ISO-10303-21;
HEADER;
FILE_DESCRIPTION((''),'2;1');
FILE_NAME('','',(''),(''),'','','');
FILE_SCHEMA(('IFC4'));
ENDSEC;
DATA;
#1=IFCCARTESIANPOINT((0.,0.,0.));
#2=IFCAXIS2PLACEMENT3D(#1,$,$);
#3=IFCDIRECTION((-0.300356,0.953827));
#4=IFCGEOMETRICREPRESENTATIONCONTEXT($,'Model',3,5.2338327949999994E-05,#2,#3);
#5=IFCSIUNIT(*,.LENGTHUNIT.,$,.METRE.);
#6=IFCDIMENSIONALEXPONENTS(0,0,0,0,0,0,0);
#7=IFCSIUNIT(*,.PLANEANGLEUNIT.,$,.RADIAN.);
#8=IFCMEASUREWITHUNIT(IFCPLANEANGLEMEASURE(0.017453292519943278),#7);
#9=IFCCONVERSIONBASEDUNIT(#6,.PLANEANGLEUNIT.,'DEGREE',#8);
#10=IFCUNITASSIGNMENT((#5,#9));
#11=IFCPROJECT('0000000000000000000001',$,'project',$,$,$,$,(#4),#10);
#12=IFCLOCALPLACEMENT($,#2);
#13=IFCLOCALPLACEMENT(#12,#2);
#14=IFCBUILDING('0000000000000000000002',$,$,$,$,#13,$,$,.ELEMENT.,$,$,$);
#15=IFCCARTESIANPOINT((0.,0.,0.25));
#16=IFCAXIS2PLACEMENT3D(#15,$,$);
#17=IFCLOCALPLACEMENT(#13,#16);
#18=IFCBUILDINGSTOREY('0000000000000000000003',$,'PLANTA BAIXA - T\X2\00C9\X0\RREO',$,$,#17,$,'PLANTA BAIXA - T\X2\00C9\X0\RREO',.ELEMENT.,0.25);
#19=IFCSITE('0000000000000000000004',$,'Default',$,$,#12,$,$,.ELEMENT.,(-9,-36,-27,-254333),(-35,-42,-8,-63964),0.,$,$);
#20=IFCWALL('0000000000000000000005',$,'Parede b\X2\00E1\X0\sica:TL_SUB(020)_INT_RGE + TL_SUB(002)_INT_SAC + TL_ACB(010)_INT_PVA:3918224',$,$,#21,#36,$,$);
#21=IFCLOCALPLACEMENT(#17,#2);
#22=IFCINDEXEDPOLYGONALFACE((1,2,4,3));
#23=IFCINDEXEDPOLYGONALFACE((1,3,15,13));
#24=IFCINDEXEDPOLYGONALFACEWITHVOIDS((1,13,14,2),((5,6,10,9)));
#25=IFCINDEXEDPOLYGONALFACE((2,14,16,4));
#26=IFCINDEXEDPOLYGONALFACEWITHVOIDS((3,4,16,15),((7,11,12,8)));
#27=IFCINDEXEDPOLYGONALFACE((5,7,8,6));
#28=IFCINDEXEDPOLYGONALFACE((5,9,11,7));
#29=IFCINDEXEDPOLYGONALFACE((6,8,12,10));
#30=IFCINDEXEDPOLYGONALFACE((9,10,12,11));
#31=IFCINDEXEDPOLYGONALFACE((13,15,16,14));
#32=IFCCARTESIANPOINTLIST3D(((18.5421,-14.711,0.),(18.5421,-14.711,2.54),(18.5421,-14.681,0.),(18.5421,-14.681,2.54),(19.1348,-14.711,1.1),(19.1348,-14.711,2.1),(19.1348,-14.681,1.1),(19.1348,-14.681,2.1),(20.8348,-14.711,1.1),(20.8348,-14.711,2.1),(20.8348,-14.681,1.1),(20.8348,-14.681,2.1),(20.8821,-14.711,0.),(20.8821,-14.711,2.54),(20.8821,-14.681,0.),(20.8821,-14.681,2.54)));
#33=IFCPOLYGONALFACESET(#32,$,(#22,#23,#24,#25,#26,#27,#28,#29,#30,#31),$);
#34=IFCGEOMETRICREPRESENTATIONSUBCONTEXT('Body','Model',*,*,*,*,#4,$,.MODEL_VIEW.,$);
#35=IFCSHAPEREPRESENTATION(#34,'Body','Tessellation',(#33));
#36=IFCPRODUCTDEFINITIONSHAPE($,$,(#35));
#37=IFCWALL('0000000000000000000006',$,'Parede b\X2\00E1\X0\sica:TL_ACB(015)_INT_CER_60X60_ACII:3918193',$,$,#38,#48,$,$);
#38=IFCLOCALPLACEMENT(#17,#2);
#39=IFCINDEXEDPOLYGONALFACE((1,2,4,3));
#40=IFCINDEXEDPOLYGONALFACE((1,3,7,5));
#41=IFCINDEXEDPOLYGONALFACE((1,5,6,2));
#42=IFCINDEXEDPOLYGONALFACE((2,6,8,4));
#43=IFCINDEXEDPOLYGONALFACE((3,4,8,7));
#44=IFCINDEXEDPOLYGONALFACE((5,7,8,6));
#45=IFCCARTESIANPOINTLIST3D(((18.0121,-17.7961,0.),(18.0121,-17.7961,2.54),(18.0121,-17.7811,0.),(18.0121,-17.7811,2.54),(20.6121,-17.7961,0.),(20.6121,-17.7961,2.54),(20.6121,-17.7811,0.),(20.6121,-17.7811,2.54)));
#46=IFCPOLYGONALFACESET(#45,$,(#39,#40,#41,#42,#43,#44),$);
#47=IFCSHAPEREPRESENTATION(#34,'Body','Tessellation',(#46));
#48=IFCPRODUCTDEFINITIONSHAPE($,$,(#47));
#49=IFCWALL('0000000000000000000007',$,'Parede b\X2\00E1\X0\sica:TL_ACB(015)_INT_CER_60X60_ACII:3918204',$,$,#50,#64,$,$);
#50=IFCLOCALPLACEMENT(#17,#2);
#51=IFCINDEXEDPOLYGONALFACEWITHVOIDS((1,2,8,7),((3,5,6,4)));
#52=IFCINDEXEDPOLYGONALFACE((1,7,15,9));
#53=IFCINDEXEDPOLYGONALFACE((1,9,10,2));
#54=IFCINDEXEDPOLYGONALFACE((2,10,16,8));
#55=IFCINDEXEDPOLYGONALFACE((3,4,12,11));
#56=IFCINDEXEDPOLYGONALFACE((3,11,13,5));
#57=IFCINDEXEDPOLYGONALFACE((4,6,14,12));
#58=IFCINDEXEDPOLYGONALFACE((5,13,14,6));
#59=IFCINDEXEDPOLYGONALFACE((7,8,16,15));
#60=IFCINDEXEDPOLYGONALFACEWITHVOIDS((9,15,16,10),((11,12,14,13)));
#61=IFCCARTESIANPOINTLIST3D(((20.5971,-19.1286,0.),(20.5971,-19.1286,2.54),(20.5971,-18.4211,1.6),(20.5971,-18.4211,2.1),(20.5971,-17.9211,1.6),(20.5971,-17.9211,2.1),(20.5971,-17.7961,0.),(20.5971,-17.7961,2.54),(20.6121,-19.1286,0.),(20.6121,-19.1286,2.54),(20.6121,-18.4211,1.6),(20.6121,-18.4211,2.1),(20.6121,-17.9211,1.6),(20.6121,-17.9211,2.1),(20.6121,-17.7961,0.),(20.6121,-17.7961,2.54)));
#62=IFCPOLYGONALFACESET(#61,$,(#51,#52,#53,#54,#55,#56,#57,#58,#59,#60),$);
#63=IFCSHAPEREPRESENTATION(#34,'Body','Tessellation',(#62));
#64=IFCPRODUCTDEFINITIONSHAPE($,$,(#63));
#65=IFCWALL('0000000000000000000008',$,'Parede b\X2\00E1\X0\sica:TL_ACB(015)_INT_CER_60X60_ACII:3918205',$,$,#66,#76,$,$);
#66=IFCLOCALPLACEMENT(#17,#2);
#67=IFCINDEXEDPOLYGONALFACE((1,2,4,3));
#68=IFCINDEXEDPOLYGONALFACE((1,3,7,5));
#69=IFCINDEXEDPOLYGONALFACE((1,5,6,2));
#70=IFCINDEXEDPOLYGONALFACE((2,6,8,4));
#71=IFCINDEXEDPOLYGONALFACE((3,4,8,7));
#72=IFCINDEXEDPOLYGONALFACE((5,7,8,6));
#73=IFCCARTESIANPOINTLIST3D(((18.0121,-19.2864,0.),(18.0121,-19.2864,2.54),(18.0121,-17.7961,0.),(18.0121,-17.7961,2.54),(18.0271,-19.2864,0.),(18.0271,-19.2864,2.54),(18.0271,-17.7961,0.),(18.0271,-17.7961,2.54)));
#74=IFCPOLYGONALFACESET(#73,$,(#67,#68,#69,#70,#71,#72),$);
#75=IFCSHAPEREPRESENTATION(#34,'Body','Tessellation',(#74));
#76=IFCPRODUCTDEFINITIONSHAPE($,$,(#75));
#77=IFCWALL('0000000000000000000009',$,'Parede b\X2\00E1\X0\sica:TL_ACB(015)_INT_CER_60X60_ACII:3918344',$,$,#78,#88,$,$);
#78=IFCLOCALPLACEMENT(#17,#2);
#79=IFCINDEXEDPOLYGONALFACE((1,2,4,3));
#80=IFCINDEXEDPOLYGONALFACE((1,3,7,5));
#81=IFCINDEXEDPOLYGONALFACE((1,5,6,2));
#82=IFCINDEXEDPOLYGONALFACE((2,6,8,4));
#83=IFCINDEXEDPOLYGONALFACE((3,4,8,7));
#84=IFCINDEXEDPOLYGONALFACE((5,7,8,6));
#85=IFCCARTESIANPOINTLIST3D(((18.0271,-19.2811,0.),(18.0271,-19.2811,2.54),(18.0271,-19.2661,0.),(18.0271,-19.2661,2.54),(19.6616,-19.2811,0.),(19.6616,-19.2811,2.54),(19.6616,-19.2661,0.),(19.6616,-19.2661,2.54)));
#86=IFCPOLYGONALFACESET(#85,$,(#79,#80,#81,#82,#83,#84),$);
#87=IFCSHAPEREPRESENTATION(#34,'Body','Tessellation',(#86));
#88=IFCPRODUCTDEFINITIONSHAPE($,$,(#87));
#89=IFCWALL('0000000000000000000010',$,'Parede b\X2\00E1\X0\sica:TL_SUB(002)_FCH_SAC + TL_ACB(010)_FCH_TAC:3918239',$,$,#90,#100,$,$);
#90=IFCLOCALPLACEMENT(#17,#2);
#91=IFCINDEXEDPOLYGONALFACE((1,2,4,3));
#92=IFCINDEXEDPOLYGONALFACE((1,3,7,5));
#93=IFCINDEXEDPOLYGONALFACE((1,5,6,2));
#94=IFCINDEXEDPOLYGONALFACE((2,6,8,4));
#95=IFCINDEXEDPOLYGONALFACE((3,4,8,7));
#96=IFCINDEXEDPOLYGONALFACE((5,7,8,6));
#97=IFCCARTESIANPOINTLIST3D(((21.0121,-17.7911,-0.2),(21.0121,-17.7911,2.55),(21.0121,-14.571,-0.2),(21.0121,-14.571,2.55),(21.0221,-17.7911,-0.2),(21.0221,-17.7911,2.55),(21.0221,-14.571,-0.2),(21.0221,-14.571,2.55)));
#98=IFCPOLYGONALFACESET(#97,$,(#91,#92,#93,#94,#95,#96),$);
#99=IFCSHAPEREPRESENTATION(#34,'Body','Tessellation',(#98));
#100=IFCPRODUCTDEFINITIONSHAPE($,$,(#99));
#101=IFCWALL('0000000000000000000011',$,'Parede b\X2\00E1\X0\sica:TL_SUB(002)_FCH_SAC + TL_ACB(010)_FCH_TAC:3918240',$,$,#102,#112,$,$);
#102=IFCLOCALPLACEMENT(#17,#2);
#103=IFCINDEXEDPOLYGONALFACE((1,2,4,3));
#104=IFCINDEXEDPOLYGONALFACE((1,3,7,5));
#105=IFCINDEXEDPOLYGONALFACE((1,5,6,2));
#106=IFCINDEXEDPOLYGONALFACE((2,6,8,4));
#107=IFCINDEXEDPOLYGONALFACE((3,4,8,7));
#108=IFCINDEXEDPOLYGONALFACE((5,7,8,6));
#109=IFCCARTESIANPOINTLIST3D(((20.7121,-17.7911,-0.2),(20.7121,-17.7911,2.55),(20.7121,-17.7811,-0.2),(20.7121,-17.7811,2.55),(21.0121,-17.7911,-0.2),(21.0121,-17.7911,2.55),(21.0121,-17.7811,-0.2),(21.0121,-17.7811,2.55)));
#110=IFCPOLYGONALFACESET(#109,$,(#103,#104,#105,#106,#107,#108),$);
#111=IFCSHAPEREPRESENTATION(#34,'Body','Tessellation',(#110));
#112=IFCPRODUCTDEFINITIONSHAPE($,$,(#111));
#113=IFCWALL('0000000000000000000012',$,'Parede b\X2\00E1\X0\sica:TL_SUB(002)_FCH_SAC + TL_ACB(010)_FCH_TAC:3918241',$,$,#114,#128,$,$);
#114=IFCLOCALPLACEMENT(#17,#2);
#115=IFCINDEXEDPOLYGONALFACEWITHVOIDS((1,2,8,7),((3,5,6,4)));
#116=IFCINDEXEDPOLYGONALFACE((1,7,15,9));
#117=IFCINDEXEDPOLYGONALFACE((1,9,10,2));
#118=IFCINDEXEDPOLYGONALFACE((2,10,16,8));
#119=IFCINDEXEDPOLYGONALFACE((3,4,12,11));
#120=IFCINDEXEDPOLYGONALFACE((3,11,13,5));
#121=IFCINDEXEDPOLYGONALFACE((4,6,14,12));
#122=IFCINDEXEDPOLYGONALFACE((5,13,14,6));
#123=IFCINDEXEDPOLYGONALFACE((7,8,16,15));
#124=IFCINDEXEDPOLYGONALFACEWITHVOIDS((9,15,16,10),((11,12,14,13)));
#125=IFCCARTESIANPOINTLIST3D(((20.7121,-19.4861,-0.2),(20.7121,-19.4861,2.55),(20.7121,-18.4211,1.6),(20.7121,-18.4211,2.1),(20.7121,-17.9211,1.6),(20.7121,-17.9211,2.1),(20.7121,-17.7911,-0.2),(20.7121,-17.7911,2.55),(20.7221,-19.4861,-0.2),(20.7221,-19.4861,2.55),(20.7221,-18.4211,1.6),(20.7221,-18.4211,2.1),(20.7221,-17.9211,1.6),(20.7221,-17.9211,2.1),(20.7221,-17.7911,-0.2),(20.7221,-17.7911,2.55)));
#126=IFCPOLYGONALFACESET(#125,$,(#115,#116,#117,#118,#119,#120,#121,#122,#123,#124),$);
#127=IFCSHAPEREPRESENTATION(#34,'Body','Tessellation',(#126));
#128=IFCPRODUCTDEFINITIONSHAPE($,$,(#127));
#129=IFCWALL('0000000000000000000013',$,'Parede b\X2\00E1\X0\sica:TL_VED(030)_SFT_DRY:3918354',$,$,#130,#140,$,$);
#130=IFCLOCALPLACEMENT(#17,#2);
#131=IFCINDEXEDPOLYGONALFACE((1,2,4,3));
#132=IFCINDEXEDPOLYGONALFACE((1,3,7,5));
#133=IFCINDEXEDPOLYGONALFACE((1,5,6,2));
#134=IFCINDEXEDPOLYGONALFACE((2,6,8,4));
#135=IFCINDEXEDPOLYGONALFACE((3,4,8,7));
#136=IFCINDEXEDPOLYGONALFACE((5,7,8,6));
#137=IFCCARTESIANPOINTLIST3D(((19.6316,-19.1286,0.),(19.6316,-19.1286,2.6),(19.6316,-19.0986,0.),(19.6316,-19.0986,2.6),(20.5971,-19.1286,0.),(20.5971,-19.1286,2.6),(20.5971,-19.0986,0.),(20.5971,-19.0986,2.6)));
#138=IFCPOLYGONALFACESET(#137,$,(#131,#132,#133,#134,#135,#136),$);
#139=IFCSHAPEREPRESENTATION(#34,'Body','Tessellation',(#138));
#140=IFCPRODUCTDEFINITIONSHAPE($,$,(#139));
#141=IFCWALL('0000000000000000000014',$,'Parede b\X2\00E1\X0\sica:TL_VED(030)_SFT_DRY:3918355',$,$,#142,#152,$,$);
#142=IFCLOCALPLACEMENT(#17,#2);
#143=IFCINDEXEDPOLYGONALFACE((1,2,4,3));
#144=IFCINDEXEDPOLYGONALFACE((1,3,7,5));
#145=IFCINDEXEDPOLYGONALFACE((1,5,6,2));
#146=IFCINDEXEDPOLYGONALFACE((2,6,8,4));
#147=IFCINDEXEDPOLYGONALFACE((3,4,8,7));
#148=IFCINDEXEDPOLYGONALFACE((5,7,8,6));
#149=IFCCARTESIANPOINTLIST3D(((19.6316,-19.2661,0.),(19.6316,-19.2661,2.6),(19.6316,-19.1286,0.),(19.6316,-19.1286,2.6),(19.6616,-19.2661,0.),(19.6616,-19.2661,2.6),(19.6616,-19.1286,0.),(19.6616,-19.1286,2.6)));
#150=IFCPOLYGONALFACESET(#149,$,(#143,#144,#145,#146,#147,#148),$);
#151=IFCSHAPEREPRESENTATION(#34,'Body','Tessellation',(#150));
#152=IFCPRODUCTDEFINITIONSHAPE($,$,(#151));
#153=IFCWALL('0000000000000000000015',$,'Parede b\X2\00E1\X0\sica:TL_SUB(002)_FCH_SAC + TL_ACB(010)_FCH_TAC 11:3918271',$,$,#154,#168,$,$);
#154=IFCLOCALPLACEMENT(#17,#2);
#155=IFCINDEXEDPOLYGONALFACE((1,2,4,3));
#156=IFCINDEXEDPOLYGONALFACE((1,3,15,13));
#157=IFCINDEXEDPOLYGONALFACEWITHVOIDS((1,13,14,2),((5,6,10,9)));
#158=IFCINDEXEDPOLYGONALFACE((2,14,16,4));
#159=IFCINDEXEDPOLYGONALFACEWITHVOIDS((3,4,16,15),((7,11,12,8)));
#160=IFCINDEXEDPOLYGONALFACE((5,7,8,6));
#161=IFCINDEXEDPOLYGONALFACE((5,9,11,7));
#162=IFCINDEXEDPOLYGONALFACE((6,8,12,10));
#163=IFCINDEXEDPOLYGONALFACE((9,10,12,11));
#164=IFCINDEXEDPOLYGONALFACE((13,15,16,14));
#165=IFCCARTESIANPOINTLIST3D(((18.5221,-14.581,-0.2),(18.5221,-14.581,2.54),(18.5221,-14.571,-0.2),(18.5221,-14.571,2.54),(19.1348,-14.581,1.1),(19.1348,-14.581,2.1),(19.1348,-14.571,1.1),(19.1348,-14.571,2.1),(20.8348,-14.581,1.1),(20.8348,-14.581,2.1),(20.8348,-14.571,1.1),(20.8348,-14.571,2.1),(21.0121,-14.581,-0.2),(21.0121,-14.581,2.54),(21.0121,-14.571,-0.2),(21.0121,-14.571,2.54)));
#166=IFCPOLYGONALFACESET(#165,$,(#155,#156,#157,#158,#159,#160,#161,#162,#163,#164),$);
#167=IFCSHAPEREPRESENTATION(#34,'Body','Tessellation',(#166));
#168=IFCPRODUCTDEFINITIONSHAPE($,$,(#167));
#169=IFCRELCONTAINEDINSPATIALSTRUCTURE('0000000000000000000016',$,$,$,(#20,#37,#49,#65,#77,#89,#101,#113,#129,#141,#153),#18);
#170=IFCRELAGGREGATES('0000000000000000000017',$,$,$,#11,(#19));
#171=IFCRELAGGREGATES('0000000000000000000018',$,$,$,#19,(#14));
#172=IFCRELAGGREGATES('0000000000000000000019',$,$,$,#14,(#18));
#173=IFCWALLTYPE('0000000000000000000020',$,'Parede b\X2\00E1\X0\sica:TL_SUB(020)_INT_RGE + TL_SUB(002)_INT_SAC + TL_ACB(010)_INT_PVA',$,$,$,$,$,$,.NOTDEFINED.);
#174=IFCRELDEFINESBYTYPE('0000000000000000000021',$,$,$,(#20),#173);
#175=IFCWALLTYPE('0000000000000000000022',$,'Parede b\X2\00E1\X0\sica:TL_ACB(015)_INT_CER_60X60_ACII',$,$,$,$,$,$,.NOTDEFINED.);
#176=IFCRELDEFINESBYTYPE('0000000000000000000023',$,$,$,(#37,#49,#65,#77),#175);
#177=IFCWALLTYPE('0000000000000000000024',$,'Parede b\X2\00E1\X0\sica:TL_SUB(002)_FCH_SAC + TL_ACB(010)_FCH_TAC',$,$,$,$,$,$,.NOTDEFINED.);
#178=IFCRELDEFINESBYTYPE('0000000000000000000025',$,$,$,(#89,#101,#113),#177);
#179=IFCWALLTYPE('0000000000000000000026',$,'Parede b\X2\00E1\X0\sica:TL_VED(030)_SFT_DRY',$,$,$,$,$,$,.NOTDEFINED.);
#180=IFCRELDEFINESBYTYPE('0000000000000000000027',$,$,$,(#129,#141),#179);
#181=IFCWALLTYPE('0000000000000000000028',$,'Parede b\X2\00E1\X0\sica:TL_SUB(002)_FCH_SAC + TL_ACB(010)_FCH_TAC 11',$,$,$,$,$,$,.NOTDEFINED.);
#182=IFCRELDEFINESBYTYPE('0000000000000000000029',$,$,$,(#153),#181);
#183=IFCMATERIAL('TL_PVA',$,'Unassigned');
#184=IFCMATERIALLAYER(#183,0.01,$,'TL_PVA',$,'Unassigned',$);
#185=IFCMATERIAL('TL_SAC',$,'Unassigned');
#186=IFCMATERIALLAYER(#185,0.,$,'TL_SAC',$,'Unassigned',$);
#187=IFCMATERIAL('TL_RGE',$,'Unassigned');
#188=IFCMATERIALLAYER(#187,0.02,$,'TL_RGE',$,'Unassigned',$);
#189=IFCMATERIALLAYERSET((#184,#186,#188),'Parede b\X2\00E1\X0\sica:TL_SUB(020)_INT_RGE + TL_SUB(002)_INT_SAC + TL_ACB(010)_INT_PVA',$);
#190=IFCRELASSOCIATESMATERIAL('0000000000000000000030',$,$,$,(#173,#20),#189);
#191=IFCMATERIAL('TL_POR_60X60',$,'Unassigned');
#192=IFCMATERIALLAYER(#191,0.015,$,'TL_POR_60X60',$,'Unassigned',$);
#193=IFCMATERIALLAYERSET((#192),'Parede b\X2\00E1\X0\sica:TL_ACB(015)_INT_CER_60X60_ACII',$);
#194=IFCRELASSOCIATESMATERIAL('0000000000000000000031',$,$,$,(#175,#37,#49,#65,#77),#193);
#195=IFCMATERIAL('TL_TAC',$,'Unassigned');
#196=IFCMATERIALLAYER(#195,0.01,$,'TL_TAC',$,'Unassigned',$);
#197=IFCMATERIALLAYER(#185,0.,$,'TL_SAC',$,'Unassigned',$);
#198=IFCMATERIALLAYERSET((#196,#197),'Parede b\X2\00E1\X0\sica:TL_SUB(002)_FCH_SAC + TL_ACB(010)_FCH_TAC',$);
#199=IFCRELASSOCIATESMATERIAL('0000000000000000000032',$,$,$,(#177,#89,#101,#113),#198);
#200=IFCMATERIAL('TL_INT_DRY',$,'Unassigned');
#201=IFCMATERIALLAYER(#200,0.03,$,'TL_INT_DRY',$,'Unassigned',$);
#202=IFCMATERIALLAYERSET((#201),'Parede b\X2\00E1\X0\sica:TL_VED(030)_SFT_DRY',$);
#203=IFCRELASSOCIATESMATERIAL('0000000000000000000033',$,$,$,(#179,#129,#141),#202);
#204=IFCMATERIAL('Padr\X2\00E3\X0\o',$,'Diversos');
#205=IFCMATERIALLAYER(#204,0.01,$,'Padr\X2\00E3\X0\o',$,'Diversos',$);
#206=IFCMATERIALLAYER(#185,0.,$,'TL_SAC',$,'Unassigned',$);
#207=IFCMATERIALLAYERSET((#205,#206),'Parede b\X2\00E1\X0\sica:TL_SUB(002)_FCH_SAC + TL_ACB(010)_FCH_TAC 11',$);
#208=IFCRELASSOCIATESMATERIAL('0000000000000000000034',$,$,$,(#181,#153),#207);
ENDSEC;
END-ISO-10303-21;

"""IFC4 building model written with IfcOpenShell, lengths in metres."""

from ifc_helpers import new_model, entity, si_unit, converted_unit, direction, frame, frame_2d, origin, place, context, subcontext, project, spatial, rectangle, extrude, material, layer, layer_set, layer_usage, type_object, element, save


model = new_model("IFC4")

# Units and contexts
model_context = context("Model", 3, precision=5.2338327949999994e-05, world=origin(), true_north=direction((-0.300356, 0.953827)))
body_context = subcontext(model_context, "Body", "Model", "MODEL_VIEW")
ifc_project = project(units=[si_unit("LENGTHUNIT", "METRE"), converted_unit("PLANEANGLEUNIT", "DEGREE", entity("IfcPlaneAngleMeasure", 0.017453292519943278), si_unit("PLANEANGLEUNIT", "RADIAN"), dimensions=[0, 0, 0, 0, 0, 0, 0])], contexts=[model_context])

# Site, building, storey
site_placement = place(None, origin())
site = spatial("IfcSite", under=ifc_project, at=site_placement, Name="Default", CompositionType="ELEMENT", RefLatitude=(-9, -36, -27, -254333), RefLongitude=(-35, -42, -8, -63964), RefElevation=0.0)
building_placement = place(site_placement, origin())
building = spatial("IfcBuilding", under=site, at=building_placement, CompositionType="ELEMENT")
storey_placement = place(building_placement, frame((0.0, 0.0, 0.25)))
storey = spatial("IfcBuildingStorey", under=building, at=storey_placement, Name="PLANTA BAIXA - TÉRREO", LongName="PLANTA BAIXA - TÉRREO", CompositionType="ELEMENT", Elevation=0.25)

# Shared definitions
ifc_material_1 = material(Name="TL_PVA", Category="Unassigned")
ifc_layer_1 = layer(ifc_material_1, 0.01, Name="TL_PVA", Category="Unassigned")
ifc_material_2 = material(Name="TL_SAC", Category="Unassigned")
ifc_layer_2 = layer(ifc_material_2, 0.0, Name="TL_SAC", Category="Unassigned")
ifc_material_3 = material(Name="TL_RGE", Category="Unassigned")
ifc_layer_3 = layer(ifc_material_3, 0.02, Name="TL_RGE", Category="Unassigned")
ifc_layer_set_1 = layer_set([ifc_layer_1, ifc_layer_2, ifc_layer_3], Name="Parede básica:TL_SUB(020)_INT_RGE + TL_SUB(002)_INT_SAC + TL_ACB(010)_INT_PVA")
wall_type_1 = type_object("IfcWallType", Name="Parede básica:TL_SUB(020)_INT_RGE + TL_SUB(002)_INT_SAC + TL_ACB(010)_INT_PVA", PredefinedType="NOTDEFINED", material=ifc_layer_set_1)

# Wall, opening
ifc_layer_usage_1 = layer_usage(ifc_layer_set_1, "AXIS2", "POSITIVE", -0.015)
wall_1_placement = place(storey_placement, frame((18.5421, -14.696, 0.0)))
wall_1 = element("IfcWall", 1, at=wall_1_placement, inside=storey, type_object=wall_type_1, material=ifc_layer_usage_1, Name="Parede básica:TL_SUB(020)_INT_RGE + TL_SUB(002)_INT_SAC + TL_ACB(010)_INT_PVA:3918224", context=body_context, shape_type="SweptSolid", body=[
    extrude(rectangle(XDim=2.34, YDim=0.03, at=frame_2d((1.17, 0.0), x_axis=(-1.0, 0.0))), origin(), (0.0, 0.0, 1.0), 2.54),
])
opening_1_placement = place(wall_1_placement, frame((-18.5421, 14.696, 1.1)))
element("IfcOpeningElement", 2, at=opening_1_placement, cuts=wall_1, PredefinedType="OPENING", context=body_context, shape_type="SweptSolid", body=[
    extrude(rectangle(XDim=1.0, YDim=1.7, at=frame_2d((0.0, 0.0), x_axis=(0.0, 1.0))), frame((19.9848, -16.205, 0.5), z_axis=(0.0, 1.0, 0.0), x_axis=(1.0, 0.0, 0.0)), (0.0, 0.0, 1.0), 3.048),
])

# Wall
ifc_material_4 = material(Name="TL_POR_60X60", Category="Unassigned")
ifc_layer_4 = layer(ifc_material_4, 0.015, Name="TL_POR_60X60", Category="Unassigned")
ifc_layer_set_2 = layer_set([ifc_layer_4], Name="Parede básica:TL_ACB(015)_INT_CER_60X60_ACII")
ifc_layer_usage_2 = layer_usage(ifc_layer_set_2, "AXIS2", "NEGATIVE", 0.0075)
wall_type_2 = type_object("IfcWallType", Name="Parede básica:TL_ACB(015)_INT_CER_60X60_ACII", PredefinedType="NOTDEFINED", material=ifc_layer_set_2)
wall_2_placement = place(storey_placement, frame((20.6121, -17.7886, 0.0), z_axis=(0.0, 0.0, 1.0), x_axis=(-1.0, 0.0, 0.0)))
element("IfcWall", 3, at=wall_2_placement, inside=storey, type_object=wall_type_2, material=ifc_layer_usage_2, Name="Parede básica:TL_ACB(015)_INT_CER_60X60_ACII:3918193", context=body_context, shape_type="SweptSolid", body=[
    extrude(rectangle(XDim=2.6, YDim=0.015, at=frame_2d((1.3, 0.0), x_axis=(-1.0, 0.0))), origin(), (0.0, 0.0, 1.0), 2.54),
])

# Wall, opening
ifc_layer_usage_3 = layer_usage(ifc_layer_set_2, "AXIS2", "POSITIVE", -0.0075)
wall_3_placement = place(storey_placement, frame((20.6046, -17.7961, 0.0), z_axis=(0.0, 0.0, 1.0), x_axis=(0.0, -1.0, 0.0)))
wall_3 = element("IfcWall", 4, at=wall_3_placement, inside=storey, type_object=wall_type_2, material=ifc_layer_usage_3, Name="Parede básica:TL_ACB(015)_INT_CER_60X60_ACII:3918204", context=body_context, shape_type="SweptSolid", body=[
    extrude(rectangle(XDim=1.3325, YDim=0.015, at=frame_2d((0.6662, 0.0), x_axis=(-1.0, 0.0))), origin(), (0.0, 0.0, 1.0), 2.54),
])
opening_2_placement = place(wall_3_placement, frame((-17.7961, -20.6046, 1.6)))
element("IfcOpeningElement", 5, at=opening_2_placement, cuts=wall_3, PredefinedType="OPENING", context=body_context, shape_type="SweptSolid", body=[
    extrude(rectangle(XDim=0.5, YDim=0.5, at=frame_2d((0.0, 0.0), x_axis=(1.0, 0.0))), frame((18.1711, 19.1881, 0.25), z_axis=(0.0, 1.0, 0.0), x_axis=(0.0, 0.0, 1.0)), (0.0, 0.0, 1.0), 3.048),
])

# Walls
ifc_layer_usage_4 = layer_usage(ifc_layer_set_2, "AXIS2", "POSITIVE", -0.0075)
wall_4_placement = place(storey_placement, frame((18.0196, -19.2864, 0.0), z_axis=(0.0, 0.0, 1.0), x_axis=(0.0, 1.0, 0.0)))
element("IfcWall", 6, at=wall_4_placement, inside=storey, type_object=wall_type_2, material=ifc_layer_usage_4, Name="Parede básica:TL_ACB(015)_INT_CER_60X60_ACII:3918205", context=body_context, shape_type="SweptSolid", body=[
    extrude(rectangle(XDim=1.4902, YDim=0.015, at=frame_2d((0.7451, 0.0), x_axis=(-1.0, 0.0))), origin(), (0.0, 0.0, 1.0), 2.54),
])
ifc_layer_usage_5 = layer_usage(ifc_layer_set_2, "AXIS2", "NEGATIVE", 0.0075)
wall_5_placement = place(storey_placement, frame((18.0271, -19.2736, 0.0)))
element("IfcWall", 7, at=wall_5_placement, inside=storey, type_object=wall_type_2, material=ifc_layer_usage_5, Name="Parede básica:TL_ACB(015)_INT_CER_60X60_ACII:3918344", context=body_context, shape_type="SweptSolid", body=[
    extrude(rectangle(XDim=1.6345, YDim=0.015, at=frame_2d((0.8172, 0.0), x_axis=(-1.0, 0.0))), origin(), (0.0, 0.0, 1.0), 2.54),
])
ifc_material_5 = material(Name="TL_TAC", Category="Unassigned")
ifc_layer_5 = layer(ifc_material_5, 0.01, Name="TL_TAC", Category="Unassigned")
ifc_layer_6 = layer(ifc_material_2, 0.0, Name="TL_SAC", Category="Unassigned")
ifc_layer_set_3 = layer_set([ifc_layer_5, ifc_layer_6], Name="Parede básica:TL_SUB(002)_FCH_SAC + TL_ACB(010)_FCH_TAC")
ifc_layer_usage_6 = layer_usage(ifc_layer_set_3, "AXIS2", "POSITIVE", -0.005)
wall_type_3 = type_object("IfcWallType", Name="Parede básica:TL_SUB(002)_FCH_SAC + TL_ACB(010)_FCH_TAC", PredefinedType="NOTDEFINED", material=ifc_layer_set_3)
wall_6_placement = place(storey_placement, frame((21.0171, -14.571, -0.2), z_axis=(0.0, 0.0, 1.0), x_axis=(0.0, -1.0, 0.0)))
element("IfcWall", 8, at=wall_6_placement, inside=storey, type_object=wall_type_3, material=ifc_layer_usage_6, Name="Parede básica:TL_SUB(002)_FCH_SAC + TL_ACB(010)_FCH_TAC:3918239", context=body_context, shape_type="SweptSolid", body=[
    extrude(rectangle(XDim=3.2201, YDim=0.01, at=frame_2d((1.6101, 0.0), x_axis=(-1.0, 0.0))), origin(), (0.0, 0.0, 1.0), 2.75),
])
ifc_layer_usage_7 = layer_usage(ifc_layer_set_3, "AXIS2", "POSITIVE", -0.005)
wall_7_placement = place(storey_placement, frame((21.0121, -17.7861, -0.2), z_axis=(0.0, 0.0, 1.0), x_axis=(-1.0, 0.0, 0.0)))
element("IfcWall", 9, at=wall_7_placement, inside=storey, type_object=wall_type_3, material=ifc_layer_usage_7, Name="Parede básica:TL_SUB(002)_FCH_SAC + TL_ACB(010)_FCH_TAC:3918240", context=body_context, shape_type="SweptSolid", body=[
    extrude(rectangle(XDim=0.3, YDim=0.01, at=frame_2d((0.15, 0.0), x_axis=(-1.0, 0.0))), origin(), (0.0, 0.0, 1.0), 2.75),
])

# Wall, opening
ifc_layer_usage_8 = layer_usage(ifc_layer_set_3, "AXIS2", "POSITIVE", -0.005)
wall_8_placement = place(storey_placement, frame((20.7171, -17.7911, -0.2), z_axis=(0.0, 0.0, 1.0), x_axis=(0.0, -1.0, 0.0)))
wall_8 = element("IfcWall", 10, at=wall_8_placement, inside=storey, type_object=wall_type_3, material=ifc_layer_usage_8, Name="Parede básica:TL_SUB(002)_FCH_SAC + TL_ACB(010)_FCH_TAC:3918241", context=body_context, shape_type="SweptSolid", body=[
    extrude(rectangle(XDim=1.695, YDim=0.01, at=frame_2d((0.8475, 0.0), x_axis=(-1.0, 0.0))), origin(), (0.0, 0.0, 1.0), 2.75),
])
opening_3_placement = place(wall_8_placement, frame((-17.7911, -20.7171, 1.8)))
element("IfcOpeningElement", 11, at=opening_3_placement, cuts=wall_8, PredefinedType="OPENING", context=body_context, shape_type="SweptSolid", body=[
    extrude(rectangle(XDim=0.5, YDim=0.5, at=frame_2d((0.0, 0.0), x_axis=(1.0, 0.0))), frame((18.1711, 19.1881, 0.25), z_axis=(0.0, 1.0, 0.0), x_axis=(0.0, 0.0, 1.0)), (0.0, 0.0, 1.0), 3.048),
])

# Walls
ifc_material_6 = material(Name="TL_INT_DRY", Category="Unassigned")
ifc_layer_7 = layer(ifc_material_6, 0.03, Name="TL_INT_DRY", Category="Unassigned")
ifc_layer_set_4 = layer_set([ifc_layer_7], Name="Parede básica:TL_VED(030)_SFT_DRY")
ifc_layer_usage_9 = layer_usage(ifc_layer_set_4, "AXIS2", "POSITIVE", -0.015)
wall_type_4 = type_object("IfcWallType", Name="Parede básica:TL_VED(030)_SFT_DRY", PredefinedType="NOTDEFINED", material=ifc_layer_set_4)
wall_9_placement = place(storey_placement, frame((20.5971, -19.1136, 0.0), z_axis=(0.0, 0.0, 1.0), x_axis=(-1.0, 0.0, 0.0)))
element("IfcWall", 12, at=wall_9_placement, inside=storey, type_object=wall_type_4, material=ifc_layer_usage_9, Name="Parede básica:TL_VED(030)_SFT_DRY:3918354", context=body_context, shape_type="SweptSolid", body=[
    extrude(rectangle(XDim=0.9655, YDim=0.03, at=frame_2d((0.4828, 0.0), x_axis=(-1.0, 0.0))), origin(), (0.0, 0.0, 1.0), 2.6),
])
ifc_layer_usage_10 = layer_usage(ifc_layer_set_4, "AXIS2", "POSITIVE", -0.015)
wall_10_placement = place(storey_placement, frame((19.6466, -19.1286, 0.0), z_axis=(0.0, 0.0, 1.0), x_axis=(0.0, -1.0, 0.0)))
element("IfcWall", 13, at=wall_10_placement, inside=storey, type_object=wall_type_4, material=ifc_layer_usage_10, Name="Parede básica:TL_VED(030)_SFT_DRY:3918355", context=body_context, shape_type="SweptSolid", body=[
    extrude(rectangle(XDim=0.1375, YDim=0.03, at=frame_2d((0.0688, 0.0), x_axis=(-1.0, 0.0))), origin(), (0.0, 0.0, 1.0), 2.6),
])

# Wall, opening
ifc_material_7 = material(Name="Padrão", Category="Diversos")
ifc_layer_8 = layer(ifc_material_7, 0.01, Name="Padrão", Category="Diversos")
ifc_layer_9 = layer(ifc_material_2, 0.0, Name="TL_SAC", Category="Unassigned")
ifc_layer_set_5 = layer_set([ifc_layer_8, ifc_layer_9], Name="Parede básica:TL_SUB(002)_FCH_SAC + TL_ACB(010)_FCH_TAC 11")
ifc_layer_usage_11 = layer_usage(ifc_layer_set_5, "AXIS2", "POSITIVE", -0.005)
wall_type_5 = type_object("IfcWallType", Name="Parede básica:TL_SUB(002)_FCH_SAC + TL_ACB(010)_FCH_TAC 11", PredefinedType="NOTDEFINED", material=ifc_layer_set_5)
wall_11_placement = place(storey_placement, frame((18.5221, -14.576, -0.2)))
wall_11 = element("IfcWall", 14, at=wall_11_placement, inside=storey, type_object=wall_type_5, material=ifc_layer_usage_11, Name="Parede básica:TL_SUB(002)_FCH_SAC + TL_ACB(010)_FCH_TAC 11:3918271", context=body_context, shape_type="SweptSolid", body=[
    extrude(rectangle(XDim=2.49, YDim=0.01, at=frame_2d((1.245, 0.0), x_axis=(-1.0, 0.0))), origin(), (0.0, 0.0, 1.0), 2.74),
])
opening_4_placement = place(wall_11_placement, frame((-18.5221, 14.576, 1.3)))
element("IfcOpeningElement", 15, at=opening_4_placement, cuts=wall_11, PredefinedType="OPENING", context=body_context, shape_type="SweptSolid", body=[
    extrude(rectangle(XDim=1.0, YDim=1.7, at=frame_2d((0.0, 0.0), x_axis=(0.0, 1.0))), frame((19.9848, -16.205, 0.5), z_axis=(0.0, 1.0, 0.0), x_axis=(1.0, 0.0, 0.0)), (0.0, 0.0, 1.0), 3.048),
])

save(model, "model.ifc")
